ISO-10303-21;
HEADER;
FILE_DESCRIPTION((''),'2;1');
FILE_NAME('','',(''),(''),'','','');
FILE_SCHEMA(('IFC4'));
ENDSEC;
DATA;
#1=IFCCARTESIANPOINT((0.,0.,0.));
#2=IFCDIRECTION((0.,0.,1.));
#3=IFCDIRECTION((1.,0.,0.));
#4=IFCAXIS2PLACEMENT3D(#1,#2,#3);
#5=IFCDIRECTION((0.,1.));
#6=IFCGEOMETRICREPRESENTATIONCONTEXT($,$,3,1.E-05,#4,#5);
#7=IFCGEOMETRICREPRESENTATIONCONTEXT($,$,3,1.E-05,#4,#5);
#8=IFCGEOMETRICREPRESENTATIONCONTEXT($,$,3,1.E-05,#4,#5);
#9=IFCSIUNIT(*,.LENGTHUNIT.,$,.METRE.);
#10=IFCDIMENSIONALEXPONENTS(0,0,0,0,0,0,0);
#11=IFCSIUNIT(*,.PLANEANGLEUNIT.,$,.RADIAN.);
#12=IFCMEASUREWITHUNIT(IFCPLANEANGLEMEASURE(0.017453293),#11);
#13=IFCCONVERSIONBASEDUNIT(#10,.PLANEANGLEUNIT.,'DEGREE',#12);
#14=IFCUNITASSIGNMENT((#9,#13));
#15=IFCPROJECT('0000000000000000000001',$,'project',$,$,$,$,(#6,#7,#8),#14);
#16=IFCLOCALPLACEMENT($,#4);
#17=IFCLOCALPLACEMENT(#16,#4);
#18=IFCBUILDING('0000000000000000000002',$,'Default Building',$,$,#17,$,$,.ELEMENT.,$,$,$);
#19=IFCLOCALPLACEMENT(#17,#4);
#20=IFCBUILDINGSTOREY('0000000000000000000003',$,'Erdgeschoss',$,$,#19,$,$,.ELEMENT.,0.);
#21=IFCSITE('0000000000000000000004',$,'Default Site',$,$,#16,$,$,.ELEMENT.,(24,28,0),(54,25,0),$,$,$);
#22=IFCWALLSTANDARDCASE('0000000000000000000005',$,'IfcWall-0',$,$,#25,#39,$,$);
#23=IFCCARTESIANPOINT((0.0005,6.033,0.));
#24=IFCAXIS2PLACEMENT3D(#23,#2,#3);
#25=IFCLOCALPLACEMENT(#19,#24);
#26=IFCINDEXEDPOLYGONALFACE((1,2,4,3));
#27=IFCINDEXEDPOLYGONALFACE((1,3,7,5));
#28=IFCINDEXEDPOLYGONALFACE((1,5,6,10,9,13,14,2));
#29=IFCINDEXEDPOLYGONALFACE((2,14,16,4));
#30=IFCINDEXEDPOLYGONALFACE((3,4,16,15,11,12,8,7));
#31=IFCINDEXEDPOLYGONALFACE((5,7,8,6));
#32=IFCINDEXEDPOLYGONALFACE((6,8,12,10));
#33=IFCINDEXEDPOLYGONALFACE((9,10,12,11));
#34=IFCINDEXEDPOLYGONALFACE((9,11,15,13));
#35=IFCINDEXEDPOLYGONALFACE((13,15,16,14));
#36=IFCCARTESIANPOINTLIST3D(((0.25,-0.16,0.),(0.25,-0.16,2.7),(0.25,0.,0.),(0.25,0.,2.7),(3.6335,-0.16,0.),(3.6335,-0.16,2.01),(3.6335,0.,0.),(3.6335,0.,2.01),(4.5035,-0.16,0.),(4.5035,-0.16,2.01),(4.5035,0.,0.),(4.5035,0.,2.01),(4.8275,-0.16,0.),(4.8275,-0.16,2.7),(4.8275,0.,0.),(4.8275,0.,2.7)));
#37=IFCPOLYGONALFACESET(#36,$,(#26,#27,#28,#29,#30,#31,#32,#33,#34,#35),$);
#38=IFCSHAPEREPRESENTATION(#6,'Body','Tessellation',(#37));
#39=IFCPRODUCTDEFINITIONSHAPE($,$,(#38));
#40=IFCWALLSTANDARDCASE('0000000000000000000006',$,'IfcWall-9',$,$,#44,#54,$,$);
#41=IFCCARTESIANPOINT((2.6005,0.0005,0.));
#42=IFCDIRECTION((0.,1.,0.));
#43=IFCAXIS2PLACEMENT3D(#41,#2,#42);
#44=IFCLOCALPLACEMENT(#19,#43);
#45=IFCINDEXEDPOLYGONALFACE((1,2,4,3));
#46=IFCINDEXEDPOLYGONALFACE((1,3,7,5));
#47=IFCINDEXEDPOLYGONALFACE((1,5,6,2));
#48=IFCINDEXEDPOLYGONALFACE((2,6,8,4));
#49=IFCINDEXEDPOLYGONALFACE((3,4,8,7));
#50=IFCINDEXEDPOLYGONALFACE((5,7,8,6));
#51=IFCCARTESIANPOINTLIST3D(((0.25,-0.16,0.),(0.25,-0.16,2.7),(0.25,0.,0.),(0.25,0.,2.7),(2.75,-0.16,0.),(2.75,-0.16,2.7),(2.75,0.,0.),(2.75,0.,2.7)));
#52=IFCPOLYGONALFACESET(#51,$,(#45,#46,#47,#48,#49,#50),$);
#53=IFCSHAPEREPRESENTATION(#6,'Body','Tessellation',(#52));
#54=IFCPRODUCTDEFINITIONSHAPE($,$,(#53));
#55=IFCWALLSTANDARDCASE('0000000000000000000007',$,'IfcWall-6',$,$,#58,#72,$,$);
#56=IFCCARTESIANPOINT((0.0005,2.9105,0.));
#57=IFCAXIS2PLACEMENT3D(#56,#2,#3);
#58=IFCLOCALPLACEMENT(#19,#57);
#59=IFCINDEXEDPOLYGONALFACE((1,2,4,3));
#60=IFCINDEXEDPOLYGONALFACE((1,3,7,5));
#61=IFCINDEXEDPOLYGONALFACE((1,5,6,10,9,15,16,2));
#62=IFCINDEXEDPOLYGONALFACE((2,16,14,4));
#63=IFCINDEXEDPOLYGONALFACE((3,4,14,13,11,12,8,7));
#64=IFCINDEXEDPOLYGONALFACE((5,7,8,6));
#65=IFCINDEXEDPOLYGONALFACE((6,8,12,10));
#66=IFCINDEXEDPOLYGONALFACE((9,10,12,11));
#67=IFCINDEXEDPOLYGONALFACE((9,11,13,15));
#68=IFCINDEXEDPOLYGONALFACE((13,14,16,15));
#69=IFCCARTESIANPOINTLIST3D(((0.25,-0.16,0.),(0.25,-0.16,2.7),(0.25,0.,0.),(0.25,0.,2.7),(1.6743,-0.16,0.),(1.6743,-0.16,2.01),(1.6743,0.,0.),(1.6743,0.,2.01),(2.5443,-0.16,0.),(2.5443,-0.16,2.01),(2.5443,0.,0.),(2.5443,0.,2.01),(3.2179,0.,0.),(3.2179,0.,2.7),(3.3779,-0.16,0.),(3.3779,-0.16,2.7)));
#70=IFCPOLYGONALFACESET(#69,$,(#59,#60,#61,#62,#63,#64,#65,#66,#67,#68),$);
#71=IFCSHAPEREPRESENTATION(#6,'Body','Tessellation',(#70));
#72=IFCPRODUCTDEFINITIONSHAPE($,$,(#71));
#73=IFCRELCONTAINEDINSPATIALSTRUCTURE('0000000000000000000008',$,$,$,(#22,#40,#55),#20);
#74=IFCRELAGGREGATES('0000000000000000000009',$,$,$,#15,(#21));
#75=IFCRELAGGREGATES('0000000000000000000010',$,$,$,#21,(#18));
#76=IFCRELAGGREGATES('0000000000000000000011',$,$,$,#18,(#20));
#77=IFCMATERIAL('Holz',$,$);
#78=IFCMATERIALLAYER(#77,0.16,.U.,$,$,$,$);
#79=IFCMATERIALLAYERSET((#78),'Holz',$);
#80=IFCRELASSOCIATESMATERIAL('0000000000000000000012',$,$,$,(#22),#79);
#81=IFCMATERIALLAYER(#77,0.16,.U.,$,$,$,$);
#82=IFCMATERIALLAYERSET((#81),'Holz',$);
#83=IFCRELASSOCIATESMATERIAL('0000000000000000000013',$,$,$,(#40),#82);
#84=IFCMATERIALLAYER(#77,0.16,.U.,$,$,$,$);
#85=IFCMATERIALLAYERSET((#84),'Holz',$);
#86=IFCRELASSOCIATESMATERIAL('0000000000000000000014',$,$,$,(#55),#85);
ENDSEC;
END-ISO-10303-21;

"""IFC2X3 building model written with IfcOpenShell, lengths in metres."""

from ifc_helpers import new_model, entity, si_unit, converted_unit, direction, frame, frame_2d, origin_with_axes, place, context, project, spatial, polyline, rectangle, outline, extrude, material, layer, layer_set, layer_usage, element, save


model = new_model("IFC2X3")

# Units and contexts
context_of_model_1 = context(None, 3, precision=1e-05, world=origin_with_axes(), true_north=direction((0.0, 1.0)))
context_of_model_2 = context(None, 3, precision=1e-05, world=origin_with_axes(), true_north=direction((0.0, 1.0)))
context_of_model_3 = context(None, 3, precision=1e-05, world=origin_with_axes(), true_north=direction((0.0, 1.0)))
ifc_project = project(units=[si_unit("LENGTHUNIT", "METRE"), converted_unit("PLANEANGLEUNIT", "DEGREE", entity("IfcPlaneAngleMeasure", 0.017453293), si_unit("PLANEANGLEUNIT", "RADIAN"), dimensions=[0, 0, 0, 0, 0, 0, 0])], contexts=[context_of_model_1, context_of_model_2, context_of_model_3])

# Site, building, storey
site_placement = place(None, origin_with_axes())
site = spatial("IfcSite", under=ifc_project, at=site_placement, Name="Default Site", CompositionType="ELEMENT", RefLatitude=(24, 28, 0), RefLongitude=(54, 25, 0))
building_placement = place(site_placement, origin_with_axes())
building = spatial("IfcBuilding", under=site, at=building_placement, Name="Default Building", CompositionType="ELEMENT")
storey_placement = place(building_placement, origin_with_axes())
storey = spatial("IfcBuildingStorey", under=building, at=storey_placement, Name="Erdgeschoss", CompositionType="ELEMENT", Elevation=0.0)

# Shared definitions
ifc_material_1 = material(Name="Holz")

# Wall, opening
ifc_layer_1 = layer(ifc_material_1, 0.16, ventilated="UNKNOWN")
ifc_layer_set_1 = layer_set([ifc_layer_1], Name="Holz")
ifc_layer_usage_1 = layer_usage(ifc_layer_set_1, "AXIS2", "NEGATIVE", 0.0)
wall_1_placement = place(storey_placement, frame((0.0005, 6.033, 0.0), z_axis=(0.0, 0.0, 1.0), x_axis=(1.0, 0.0, 0.0)))
wall_1 = element("IfcWallStandardCase", 1, at=wall_1_placement, inside=storey, material=ifc_layer_usage_1, Name="IfcWall-0", context=context_of_model_1, shape_type="SweptSolid", body=[
    extrude(outline(polyline([(0.25, -0.16), (4.8275, -0.16), (4.8275, 0.0), (0.25, 0.0), (0.25, -0.16)])), origin_with_axes(), (0.0, 0.0, 1.0), 2.7),
])
opening_1_placement = place(wall_1_placement, frame((4.0685, -0.16, 0.0), z_axis=(0.0, 0.0, 1.0), x_axis=(1.0, 0.0, 0.0)))
element("IfcOpeningElement", 2, at=opening_1_placement, cuts=wall_1, context=context_of_model_1, shape_type="SweptSolid", body=[
    extrude(rectangle(XDim=2.01, YDim=0.87, at=frame_2d((0.0, 1.005), x_axis=(0.0, -1.0))), frame((0.0, 0.0, 0.0), z_axis=(0.0, 1.0, 0.0), x_axis=(-1.0, 0.0, 0.0)), (0.0, 0.0, 1.0), 0.16),
])

# Wall
ifc_layer_2 = layer(ifc_material_1, 0.16, ventilated="UNKNOWN")
ifc_layer_set_2 = layer_set([ifc_layer_2], Name="Holz")
ifc_layer_usage_2 = layer_usage(ifc_layer_set_2, "AXIS2", "NEGATIVE", 0.0)
wall_2_placement = place(storey_placement, frame((2.6005, 0.0005, 0.0), z_axis=(0.0, 0.0, 1.0), x_axis=(0.0, 1.0, 0.0)))
element("IfcWallStandardCase", 3, at=wall_2_placement, inside=storey, material=ifc_layer_usage_2, Name="IfcWall-9", context=context_of_model_1, shape_type="SweptSolid", body=[
    extrude(outline(polyline([(0.25, -0.16), (2.75, -0.16), (2.75, 0.0), (0.25, 0.0), (0.25, -0.16)])), origin_with_axes(), (0.0, 0.0, 1.0), 2.7),
])

# Wall, opening
ifc_layer_3 = layer(ifc_material_1, 0.16, ventilated="UNKNOWN")
ifc_layer_set_3 = layer_set([ifc_layer_3], Name="Holz")
ifc_layer_usage_3 = layer_usage(ifc_layer_set_3, "AXIS2", "NEGATIVE", 0.0)
wall_3_placement = place(storey_placement, frame((0.0005, 2.9105, 0.0), z_axis=(0.0, 0.0, 1.0), x_axis=(1.0, 0.0, 0.0)))
wall_3 = element("IfcWallStandardCase", 4, at=wall_3_placement, inside=storey, material=ifc_layer_usage_3, Name="IfcWall-6", context=context_of_model_1, shape_type="SweptSolid", body=[
    extrude(outline(polyline([(0.25, -0.16), (3.3779, -0.16), (3.2179, 0.0), (0.25, 0.0), (0.25, -0.16)])), origin_with_axes(), (0.0, 0.0, 1.0), 2.7),
])
opening_2_placement = place(wall_3_placement, frame((2.1093, -0.16, 0.0), z_axis=(0.0, 0.0, 1.0), x_axis=(1.0, 0.0, 0.0)))
element("IfcOpeningElement", 5, at=opening_2_placement, cuts=wall_3, context=context_of_model_1, shape_type="SweptSolid", body=[
    extrude(rectangle(XDim=2.01, YDim=0.87, at=frame_2d((0.0, 1.005), x_axis=(0.0, -1.0))), frame((0.0, 0.0, 0.0), z_axis=(0.0, 1.0, 0.0), x_axis=(-1.0, 0.0, 0.0)), (0.0, 0.0, 1.0), 0.16),
])

save(model, "model.ifc")
